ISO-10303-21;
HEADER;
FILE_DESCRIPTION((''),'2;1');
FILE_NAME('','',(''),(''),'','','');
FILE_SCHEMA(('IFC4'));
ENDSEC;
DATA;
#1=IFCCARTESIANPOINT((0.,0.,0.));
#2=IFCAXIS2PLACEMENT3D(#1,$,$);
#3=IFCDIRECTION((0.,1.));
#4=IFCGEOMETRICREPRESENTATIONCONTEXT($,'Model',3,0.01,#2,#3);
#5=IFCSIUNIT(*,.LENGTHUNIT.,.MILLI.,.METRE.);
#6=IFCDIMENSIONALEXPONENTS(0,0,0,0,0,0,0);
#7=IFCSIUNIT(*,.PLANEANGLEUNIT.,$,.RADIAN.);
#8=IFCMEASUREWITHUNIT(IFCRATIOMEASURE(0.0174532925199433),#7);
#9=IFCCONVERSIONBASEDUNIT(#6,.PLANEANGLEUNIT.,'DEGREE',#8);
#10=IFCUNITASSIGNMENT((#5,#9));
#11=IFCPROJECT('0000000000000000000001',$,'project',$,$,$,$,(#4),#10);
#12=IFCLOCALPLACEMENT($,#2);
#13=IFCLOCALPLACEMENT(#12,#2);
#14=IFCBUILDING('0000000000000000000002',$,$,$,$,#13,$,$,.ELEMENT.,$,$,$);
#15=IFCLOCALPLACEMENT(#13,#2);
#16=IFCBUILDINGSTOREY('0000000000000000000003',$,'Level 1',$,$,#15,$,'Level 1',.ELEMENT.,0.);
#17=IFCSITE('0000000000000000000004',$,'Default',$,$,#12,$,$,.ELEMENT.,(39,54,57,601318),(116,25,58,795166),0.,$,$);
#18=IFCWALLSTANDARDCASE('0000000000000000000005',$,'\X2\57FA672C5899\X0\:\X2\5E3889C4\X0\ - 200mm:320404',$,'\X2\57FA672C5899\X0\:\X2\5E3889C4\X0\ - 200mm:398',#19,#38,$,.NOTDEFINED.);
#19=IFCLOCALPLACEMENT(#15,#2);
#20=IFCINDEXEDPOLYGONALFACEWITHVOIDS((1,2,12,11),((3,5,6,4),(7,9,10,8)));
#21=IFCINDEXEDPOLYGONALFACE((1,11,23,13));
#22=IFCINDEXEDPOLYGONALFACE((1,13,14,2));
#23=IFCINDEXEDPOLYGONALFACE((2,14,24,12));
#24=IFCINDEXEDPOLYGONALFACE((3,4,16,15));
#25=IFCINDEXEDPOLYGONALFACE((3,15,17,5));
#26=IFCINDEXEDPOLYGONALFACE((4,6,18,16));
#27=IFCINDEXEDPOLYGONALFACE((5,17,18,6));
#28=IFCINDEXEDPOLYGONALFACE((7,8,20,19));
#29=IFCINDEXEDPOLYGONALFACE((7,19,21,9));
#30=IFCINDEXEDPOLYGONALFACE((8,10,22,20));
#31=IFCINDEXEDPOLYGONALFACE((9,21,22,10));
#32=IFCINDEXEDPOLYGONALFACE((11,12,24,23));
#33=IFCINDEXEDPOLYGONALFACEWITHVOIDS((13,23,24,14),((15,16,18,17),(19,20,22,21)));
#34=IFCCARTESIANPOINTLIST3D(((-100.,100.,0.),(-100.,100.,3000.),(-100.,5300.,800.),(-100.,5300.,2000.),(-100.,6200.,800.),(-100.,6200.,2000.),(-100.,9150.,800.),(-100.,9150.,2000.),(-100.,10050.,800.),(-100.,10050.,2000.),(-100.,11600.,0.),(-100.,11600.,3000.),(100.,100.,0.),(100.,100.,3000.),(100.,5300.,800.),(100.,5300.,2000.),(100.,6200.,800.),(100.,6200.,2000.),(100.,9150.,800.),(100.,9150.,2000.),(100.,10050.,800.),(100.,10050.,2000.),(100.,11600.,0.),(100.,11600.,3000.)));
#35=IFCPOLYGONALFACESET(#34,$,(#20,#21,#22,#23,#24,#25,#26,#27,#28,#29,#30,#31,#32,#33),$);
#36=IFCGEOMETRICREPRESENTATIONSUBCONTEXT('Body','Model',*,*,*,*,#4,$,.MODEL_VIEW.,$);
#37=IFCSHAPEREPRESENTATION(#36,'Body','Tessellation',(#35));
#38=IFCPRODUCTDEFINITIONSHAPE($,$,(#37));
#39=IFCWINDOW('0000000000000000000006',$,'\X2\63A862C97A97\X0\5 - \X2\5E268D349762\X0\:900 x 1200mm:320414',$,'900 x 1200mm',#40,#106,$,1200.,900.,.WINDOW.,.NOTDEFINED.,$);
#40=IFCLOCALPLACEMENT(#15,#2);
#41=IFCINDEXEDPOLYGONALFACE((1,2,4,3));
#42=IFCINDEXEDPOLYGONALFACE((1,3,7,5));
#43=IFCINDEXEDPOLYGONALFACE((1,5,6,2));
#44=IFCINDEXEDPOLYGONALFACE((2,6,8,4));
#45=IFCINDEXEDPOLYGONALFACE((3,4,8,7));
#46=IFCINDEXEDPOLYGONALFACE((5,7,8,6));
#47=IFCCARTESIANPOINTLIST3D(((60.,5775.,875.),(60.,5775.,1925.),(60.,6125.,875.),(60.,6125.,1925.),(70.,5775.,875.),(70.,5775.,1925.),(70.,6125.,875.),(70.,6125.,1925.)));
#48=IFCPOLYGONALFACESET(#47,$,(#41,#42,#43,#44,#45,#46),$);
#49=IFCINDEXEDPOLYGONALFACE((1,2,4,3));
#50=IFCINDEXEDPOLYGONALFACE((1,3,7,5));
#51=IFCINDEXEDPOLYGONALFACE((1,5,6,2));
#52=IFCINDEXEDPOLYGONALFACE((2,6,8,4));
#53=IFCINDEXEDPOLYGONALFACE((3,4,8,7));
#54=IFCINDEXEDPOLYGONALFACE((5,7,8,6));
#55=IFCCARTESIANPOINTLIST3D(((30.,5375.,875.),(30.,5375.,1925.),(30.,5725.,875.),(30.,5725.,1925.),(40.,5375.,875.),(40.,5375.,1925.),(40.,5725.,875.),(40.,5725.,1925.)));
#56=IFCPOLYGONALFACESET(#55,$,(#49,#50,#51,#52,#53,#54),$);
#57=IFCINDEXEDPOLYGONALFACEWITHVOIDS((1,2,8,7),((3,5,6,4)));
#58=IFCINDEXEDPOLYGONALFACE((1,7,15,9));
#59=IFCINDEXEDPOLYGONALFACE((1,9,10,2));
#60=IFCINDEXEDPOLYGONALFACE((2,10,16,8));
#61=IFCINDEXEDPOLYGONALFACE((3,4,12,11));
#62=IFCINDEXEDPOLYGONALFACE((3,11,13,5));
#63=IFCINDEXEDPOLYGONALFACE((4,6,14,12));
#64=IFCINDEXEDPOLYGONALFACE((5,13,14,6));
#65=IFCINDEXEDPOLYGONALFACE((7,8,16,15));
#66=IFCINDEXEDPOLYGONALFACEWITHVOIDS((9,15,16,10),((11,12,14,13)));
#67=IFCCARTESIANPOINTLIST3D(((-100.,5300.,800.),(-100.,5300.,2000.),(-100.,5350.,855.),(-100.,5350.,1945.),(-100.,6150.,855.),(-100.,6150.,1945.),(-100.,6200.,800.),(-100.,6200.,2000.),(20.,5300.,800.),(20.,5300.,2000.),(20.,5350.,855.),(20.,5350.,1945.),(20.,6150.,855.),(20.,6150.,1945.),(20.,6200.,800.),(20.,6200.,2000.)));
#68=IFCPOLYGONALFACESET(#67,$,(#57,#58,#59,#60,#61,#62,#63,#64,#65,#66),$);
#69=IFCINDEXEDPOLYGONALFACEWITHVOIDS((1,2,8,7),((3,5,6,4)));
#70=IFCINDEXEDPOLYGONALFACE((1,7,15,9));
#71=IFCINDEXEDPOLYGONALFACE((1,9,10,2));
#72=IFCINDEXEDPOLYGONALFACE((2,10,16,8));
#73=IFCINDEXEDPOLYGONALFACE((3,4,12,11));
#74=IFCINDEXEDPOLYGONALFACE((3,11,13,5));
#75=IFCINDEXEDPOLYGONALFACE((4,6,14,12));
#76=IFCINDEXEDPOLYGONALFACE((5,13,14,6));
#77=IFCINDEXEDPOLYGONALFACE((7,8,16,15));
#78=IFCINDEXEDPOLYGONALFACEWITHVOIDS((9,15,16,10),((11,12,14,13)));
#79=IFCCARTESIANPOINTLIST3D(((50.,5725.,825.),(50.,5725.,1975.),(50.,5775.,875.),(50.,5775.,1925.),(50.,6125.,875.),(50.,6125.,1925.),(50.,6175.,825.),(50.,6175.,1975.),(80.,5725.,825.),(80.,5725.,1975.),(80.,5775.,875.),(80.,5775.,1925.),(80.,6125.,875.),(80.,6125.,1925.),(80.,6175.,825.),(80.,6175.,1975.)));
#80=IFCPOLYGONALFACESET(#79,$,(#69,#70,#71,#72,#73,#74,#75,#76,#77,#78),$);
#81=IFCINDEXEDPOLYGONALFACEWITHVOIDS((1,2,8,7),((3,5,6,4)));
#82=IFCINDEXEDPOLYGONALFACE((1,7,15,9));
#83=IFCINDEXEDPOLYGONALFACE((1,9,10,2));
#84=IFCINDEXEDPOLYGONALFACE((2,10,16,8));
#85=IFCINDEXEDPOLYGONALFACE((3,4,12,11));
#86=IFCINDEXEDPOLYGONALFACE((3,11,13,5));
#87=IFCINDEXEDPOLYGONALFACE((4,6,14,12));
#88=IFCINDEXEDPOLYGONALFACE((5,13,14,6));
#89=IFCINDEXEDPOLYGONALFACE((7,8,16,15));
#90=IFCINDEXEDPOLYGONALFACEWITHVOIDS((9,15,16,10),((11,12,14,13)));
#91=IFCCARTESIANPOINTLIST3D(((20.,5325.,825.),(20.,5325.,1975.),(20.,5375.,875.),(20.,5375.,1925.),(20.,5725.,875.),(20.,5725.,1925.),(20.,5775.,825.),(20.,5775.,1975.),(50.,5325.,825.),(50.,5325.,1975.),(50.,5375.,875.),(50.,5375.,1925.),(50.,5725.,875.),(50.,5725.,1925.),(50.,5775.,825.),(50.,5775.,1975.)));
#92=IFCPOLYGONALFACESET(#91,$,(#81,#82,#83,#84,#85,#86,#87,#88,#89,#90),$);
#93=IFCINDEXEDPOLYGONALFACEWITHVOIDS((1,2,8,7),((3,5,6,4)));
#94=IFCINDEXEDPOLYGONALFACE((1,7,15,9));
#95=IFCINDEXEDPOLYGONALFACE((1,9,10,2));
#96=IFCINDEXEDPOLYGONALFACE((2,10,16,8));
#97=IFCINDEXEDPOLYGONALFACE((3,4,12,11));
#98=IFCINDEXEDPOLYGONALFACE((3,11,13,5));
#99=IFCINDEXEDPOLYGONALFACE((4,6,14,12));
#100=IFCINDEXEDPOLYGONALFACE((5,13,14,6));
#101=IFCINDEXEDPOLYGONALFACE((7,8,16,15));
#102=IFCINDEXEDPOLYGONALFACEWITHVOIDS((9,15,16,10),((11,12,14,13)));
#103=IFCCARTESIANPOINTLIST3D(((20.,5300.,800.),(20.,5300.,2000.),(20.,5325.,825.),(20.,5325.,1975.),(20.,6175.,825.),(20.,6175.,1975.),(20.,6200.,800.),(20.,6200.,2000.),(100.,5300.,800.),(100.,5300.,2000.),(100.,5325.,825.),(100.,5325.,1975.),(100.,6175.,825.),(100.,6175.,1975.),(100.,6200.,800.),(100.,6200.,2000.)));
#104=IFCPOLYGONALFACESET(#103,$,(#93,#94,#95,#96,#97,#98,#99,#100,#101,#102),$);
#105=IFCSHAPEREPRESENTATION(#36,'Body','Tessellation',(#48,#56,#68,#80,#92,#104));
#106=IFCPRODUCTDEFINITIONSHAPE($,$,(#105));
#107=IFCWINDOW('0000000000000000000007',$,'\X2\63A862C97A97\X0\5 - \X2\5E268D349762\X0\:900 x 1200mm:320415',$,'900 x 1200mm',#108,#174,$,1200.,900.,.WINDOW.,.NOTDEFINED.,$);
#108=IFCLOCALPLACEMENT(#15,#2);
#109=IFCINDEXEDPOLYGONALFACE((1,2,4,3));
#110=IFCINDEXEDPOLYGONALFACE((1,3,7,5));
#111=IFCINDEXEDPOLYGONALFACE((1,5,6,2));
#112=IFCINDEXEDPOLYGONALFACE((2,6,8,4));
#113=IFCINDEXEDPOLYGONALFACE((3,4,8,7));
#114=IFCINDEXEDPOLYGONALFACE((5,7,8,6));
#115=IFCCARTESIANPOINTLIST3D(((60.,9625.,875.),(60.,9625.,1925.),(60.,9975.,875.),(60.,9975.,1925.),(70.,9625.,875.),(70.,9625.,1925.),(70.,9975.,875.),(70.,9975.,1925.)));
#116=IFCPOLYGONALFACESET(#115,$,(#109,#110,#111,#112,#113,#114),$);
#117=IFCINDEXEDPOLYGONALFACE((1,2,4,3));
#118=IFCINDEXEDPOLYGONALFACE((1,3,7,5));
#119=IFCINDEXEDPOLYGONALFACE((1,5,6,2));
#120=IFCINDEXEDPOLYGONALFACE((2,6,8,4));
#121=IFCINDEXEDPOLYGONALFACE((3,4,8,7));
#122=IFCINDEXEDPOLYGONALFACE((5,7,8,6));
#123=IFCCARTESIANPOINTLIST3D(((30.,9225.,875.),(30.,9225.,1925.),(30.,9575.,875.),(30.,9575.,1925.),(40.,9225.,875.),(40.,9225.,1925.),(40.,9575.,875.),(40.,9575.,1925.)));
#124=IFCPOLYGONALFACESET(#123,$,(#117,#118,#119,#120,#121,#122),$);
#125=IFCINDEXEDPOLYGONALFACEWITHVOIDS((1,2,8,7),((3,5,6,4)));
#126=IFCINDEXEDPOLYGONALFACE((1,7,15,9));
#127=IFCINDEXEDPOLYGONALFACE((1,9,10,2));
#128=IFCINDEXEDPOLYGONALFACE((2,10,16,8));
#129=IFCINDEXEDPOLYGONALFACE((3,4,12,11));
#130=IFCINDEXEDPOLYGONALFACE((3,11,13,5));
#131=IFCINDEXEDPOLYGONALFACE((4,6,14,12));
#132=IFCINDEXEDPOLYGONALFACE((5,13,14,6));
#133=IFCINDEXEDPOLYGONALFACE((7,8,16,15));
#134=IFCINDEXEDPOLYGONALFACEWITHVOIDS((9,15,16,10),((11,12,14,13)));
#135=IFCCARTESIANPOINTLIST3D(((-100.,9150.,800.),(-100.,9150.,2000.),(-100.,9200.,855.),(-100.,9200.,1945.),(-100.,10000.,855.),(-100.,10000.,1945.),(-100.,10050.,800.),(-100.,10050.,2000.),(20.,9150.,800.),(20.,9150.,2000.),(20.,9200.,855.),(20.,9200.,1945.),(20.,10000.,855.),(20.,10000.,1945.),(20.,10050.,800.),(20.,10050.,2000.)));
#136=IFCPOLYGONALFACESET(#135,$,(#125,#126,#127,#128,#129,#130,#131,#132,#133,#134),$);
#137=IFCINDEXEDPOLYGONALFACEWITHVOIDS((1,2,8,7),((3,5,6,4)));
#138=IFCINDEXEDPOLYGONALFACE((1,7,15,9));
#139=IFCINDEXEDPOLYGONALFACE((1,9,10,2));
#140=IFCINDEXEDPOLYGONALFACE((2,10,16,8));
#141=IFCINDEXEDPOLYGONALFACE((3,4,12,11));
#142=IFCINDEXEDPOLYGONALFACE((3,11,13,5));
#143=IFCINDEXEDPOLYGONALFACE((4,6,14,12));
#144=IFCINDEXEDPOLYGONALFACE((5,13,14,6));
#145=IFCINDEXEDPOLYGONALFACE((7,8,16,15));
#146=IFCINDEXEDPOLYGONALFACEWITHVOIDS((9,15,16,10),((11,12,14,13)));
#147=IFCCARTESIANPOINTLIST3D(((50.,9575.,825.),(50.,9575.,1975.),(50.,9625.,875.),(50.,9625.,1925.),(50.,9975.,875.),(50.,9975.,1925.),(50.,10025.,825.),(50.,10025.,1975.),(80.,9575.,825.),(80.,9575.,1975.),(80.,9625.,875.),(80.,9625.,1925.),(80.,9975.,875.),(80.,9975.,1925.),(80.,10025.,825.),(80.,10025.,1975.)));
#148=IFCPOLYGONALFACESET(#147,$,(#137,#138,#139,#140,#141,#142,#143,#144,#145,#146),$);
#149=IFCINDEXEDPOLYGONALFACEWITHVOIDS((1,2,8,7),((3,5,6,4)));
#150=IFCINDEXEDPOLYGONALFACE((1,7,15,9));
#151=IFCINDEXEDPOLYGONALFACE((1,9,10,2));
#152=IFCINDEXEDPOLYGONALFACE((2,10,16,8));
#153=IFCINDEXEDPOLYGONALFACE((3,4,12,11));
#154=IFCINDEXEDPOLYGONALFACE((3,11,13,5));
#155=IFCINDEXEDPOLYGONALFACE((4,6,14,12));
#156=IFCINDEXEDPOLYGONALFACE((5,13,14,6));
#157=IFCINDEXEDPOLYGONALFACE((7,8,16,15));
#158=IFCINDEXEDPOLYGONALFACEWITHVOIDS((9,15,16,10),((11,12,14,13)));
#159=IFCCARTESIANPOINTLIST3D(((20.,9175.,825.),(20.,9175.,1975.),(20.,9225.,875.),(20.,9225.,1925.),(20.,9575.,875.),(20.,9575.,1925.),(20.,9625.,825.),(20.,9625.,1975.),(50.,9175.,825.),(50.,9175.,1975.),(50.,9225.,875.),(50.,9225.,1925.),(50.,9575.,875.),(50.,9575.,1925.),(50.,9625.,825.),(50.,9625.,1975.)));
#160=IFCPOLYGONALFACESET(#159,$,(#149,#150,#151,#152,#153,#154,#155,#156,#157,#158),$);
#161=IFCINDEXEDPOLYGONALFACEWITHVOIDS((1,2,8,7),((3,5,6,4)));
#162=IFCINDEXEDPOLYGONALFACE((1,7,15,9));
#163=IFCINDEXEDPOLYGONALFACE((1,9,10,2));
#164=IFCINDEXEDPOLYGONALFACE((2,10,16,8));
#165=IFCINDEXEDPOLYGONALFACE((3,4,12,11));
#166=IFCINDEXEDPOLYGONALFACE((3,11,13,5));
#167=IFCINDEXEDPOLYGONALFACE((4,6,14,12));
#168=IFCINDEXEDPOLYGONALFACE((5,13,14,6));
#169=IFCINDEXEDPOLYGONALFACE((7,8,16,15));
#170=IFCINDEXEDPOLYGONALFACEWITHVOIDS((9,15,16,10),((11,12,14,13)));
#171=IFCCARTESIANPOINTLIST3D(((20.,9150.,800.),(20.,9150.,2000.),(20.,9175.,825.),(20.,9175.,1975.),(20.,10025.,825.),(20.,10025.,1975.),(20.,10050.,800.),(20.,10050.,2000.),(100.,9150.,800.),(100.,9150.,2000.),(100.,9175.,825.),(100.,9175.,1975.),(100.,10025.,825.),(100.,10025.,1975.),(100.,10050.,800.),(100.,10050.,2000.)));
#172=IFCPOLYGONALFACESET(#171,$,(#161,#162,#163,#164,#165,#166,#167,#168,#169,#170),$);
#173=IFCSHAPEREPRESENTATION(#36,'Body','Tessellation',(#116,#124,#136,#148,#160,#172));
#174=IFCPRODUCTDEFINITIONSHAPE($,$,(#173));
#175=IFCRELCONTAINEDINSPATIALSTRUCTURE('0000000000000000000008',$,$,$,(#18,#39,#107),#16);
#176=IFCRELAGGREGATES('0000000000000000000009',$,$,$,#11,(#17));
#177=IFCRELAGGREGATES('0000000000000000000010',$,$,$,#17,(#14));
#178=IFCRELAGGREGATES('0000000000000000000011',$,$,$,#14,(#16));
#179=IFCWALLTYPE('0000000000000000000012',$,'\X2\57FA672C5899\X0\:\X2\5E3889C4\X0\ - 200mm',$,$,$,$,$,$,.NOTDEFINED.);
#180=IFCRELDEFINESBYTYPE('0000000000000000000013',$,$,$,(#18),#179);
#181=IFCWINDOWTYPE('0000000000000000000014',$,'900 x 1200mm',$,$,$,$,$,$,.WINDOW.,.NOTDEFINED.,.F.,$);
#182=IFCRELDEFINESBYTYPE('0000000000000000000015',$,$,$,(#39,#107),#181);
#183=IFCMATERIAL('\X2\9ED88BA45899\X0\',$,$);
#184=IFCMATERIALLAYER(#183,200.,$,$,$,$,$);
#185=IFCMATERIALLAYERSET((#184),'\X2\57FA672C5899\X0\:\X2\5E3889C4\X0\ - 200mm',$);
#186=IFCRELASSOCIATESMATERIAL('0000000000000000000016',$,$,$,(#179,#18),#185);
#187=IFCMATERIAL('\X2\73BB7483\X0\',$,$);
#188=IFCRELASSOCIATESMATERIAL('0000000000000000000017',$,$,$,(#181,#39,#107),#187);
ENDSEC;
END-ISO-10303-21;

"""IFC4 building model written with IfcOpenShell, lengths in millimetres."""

from ifc_helpers import new_model, entity, si_unit, converted_unit, direction, frame, frame_2d, origin, origin_2d_with_axis, place, context, subcontext, project, spatial, polyline, rectangle, outline, extrude, source, transform, mapped, material, layer, layer_set, layer_usage, type_object, type_shapes, element, fill, save


model = new_model("IFC4")

# Units and contexts
model_context = context("Model", 3, precision=0.01, world=origin(), true_north=direction((0.0, 1.0)))
body_context = subcontext(model_context, "Body", "Model", "MODEL_VIEW")
ifc_project = project(units=[si_unit("LENGTHUNIT", "METRE", prefix="MILLI"), converted_unit("PLANEANGLEUNIT", "DEGREE", entity("IfcRatioMeasure", 0.0174532925199433), si_unit("PLANEANGLEUNIT", "RADIAN"), dimensions=[0, 0, 0, 0, 0, 0, 0])], contexts=[model_context])

# Site, building, storey
site_placement = place(None, origin())
site = spatial("IfcSite", under=ifc_project, at=site_placement, Name="Default", CompositionType="ELEMENT", RefLatitude=(39, 54, 57, 601318), RefLongitude=(116, 25, 58, 795166), RefElevation=0.0)
building_placement = place(site_placement, origin())
building = spatial("IfcBuilding", under=site, at=building_placement, CompositionType="ELEMENT")
storey_placement = place(building_placement, origin())
storey = spatial("IfcBuildingStorey", under=building, at=storey_placement, Name="Level 1", LongName="Level 1", CompositionType="ELEMENT", Elevation=0.0)

# Wall, openings, windows
ifc_material_1 = material(Name="默认墙")
ifc_layer_1 = layer(ifc_material_1, 200.0)
ifc_layer_set_1 = layer_set([ifc_layer_1], Name="基本墙:常规 - 200mm")
ifc_layer_usage_1 = layer_usage(ifc_layer_set_1, "AXIS2", "NEGATIVE", 100.0)
wall_type = type_object("IfcWallType", Name="基本墙:常规 - 200mm", PredefinedType="NOTDEFINED", material=ifc_layer_set_1)
wall_1_placement = place(storey_placement, frame((0.0, 100.0, 0.0), z_axis=(0.0, 0.0, 1.0), x_axis=(0.0, 1.0, 0.0)))
wall_1 = element("IfcWallStandardCase", 1, at=wall_1_placement, inside=storey, type_object=wall_type, material=ifc_layer_usage_1, Name="基本墙:常规 - 200mm:320404", ObjectType="基本墙:常规 - 200mm:398", PredefinedType="NOTDEFINED", context=body_context, shape_type="SweptSolid", body=[
    extrude(rectangle(XDim=11500.0, YDim=200.0, at=frame_2d((5750.0, 0.0), x_axis=(-1.0, 0.0))), origin(), (0.0, 0.0, 1.0), 3000.0),
])
opening_1_placement = place(wall_1_placement, frame((6100.0, 100.0, 800.0)))
opening_1 = element("IfcOpeningElement", 2, at=opening_1_placement, cuts=wall_1, ObjectType="Opening", PredefinedType="OPENING", context=body_context, shape_type="SweptSolid", body=[
    extrude(rectangle(XDim=1200.0, YDim=900.0, at=frame_2d((600.0, 450.0), x_axis=(-1.0, 0.0))), frame((0.0, 0.0, 0.0), z_axis=(0.0, -1.0, 0.0), x_axis=(0.0, 0.0, 1.0)), (0.0, 0.0, 1.0), 200.0),
])
opening_2_placement = place(wall_1_placement, frame((9950.0, 100.0, 800.0)))
opening_2 = element("IfcOpeningElement", 3, at=opening_2_placement, cuts=wall_1, ObjectType="Opening", PredefinedType="OPENING", context=body_context, shape_type="SweptSolid", body=[
    extrude(rectangle(XDim=1200.0, YDim=900.0, at=frame_2d((600.0, 450.0), x_axis=(-1.0, 0.0))), frame((0.0, 0.0, 0.0), z_axis=(0.0, -1.0, 0.0), x_axis=(0.0, 0.0, 1.0)), (0.0, 0.0, 1.0), 200.0),
])
ifc_material_2 = material(Name="玻璃")
window_type_1 = type_object("IfcWindowType", Name="900 x 1200mm", ParameterTakesPrecedence=False, PartitioningType="NOTDEFINED", PredefinedType="WINDOW", material=ifc_material_2)
shared_shape_1 = source(origin(), body_context, "Body", "SweptSolid", [
    extrude(rectangle(XDim=10.0, YDim=350.0, at=origin_2d_with_axis()), frame((250.0, 165.0, 75.0), z_axis=(0.0, 0.0, 1.0), x_axis=(0.0, -1.0, 0.0)), (0.0, 0.0, 1.0), 1050.0),
    extrude(rectangle(XDim=10.0, YDim=350.0, at=frame_2d((0.0, 0.0), x_axis=(1.0, 0.0))), frame((650.0, 135.0, 75.0), z_axis=(0.0, 0.0, 1.0), x_axis=(0.0, -1.0, 0.0)), (0.0, 0.0, 1.0), 1050.0),
    extrude(outline(polyline([(-450.0, -600.0), (450.0, -600.0), (450.0, 600.0), (-450.0, 600.0), (-450.0, -600.0)]), holes=[polyline([(400.0, -545.0), (-400.0, -545.0), (-400.0, 545.0), (400.0, 545.0), (400.0, -545.0)])]), frame((450.0, 0.0, 600.0), z_axis=(0.0, 1.0, 0.0), x_axis=(1.0, 0.0, 0.0)), (0.0, 0.0, 1.0), 120.0),
    extrude(outline(polyline([(-225.0, -575.0), (225.0, -575.0), (225.0, 575.0), (-225.0, 575.0), (-225.0, -575.0)]), holes=[polyline([(-175.0, -525.0), (-175.0, 525.0), (175.0, 525.0), (175.0, -525.0), (-175.0, -525.0)])]), frame((250.0, 150.0, 600.0), z_axis=(0.0, 1.0, 0.0), x_axis=(-1.0, 0.0, 0.0)), (0.0, 0.0, 1.0), 30.0),
    extrude(outline(polyline([(-225.0, -575.0), (225.0, -575.0), (225.0, 575.0), (-225.0, 575.0), (-225.0, -575.0)]), holes=[polyline([(-175.0, -525.0), (-175.0, 525.0), (175.0, 525.0), (175.0, -525.0), (-175.0, -525.0)])]), frame((650.0, 120.0, 600.0), z_axis=(0.0, 1.0, 0.0), x_axis=(1.0, 0.0, 0.0)), (0.0, 0.0, 1.0), 30.0),
    extrude(outline(polyline([(-450.0, -600.0), (450.0, -600.0), (450.0, 600.0), (-450.0, 600.0), (-450.0, -600.0)]), holes=[polyline([(-425.0, 575.0), (425.0, 575.0), (425.0, -575.0), (-425.0, -575.0), (-425.0, 575.0)])]), frame((450.0, 120.0, 600.0), z_axis=(0.0, 1.0, 0.0), x_axis=(1.0, 0.0, 0.0)), (0.0, 0.0, 1.0), 80.0),
])
type_shapes(window_type_1, [shared_shape_1])
window_1_placement = place(opening_1_placement, frame((0.0, 0.0, 0.0), z_axis=(0.0, 0.0, 1.0), x_axis=(-1.0, 0.0, 0.0)))
window_1 = element("IfcWindow", 4, at=window_1_placement, inside=storey, type_object=window_type_1, material=ifc_material_2, Name="推拉窗5 - 带贴面:900 x 1200mm:320414", ObjectType="900 x 1200mm", OverallHeight=1200.0, OverallWidth=900.0, PartitioningType="NOTDEFINED", PredefinedType="WINDOW", context=body_context, shape_type="MappedRepresentation", body=[
    mapped(shared_shape_1, transform((0.0, 0.0, 0.0), scale=1.0)),
])
fill(opening_1, window_1)
window_2_placement = place(opening_2_placement, frame((0.0, 0.0, 0.0), z_axis=(0.0, 0.0, 1.0), x_axis=(-1.0, 0.0, 0.0)))
window_2 = element("IfcWindow", 5, at=window_2_placement, inside=storey, type_object=window_type_1, material=ifc_material_2, Name="推拉窗5 - 带贴面:900 x 1200mm:320415", ObjectType="900 x 1200mm", OverallHeight=1200.0, OverallWidth=900.0, PartitioningType="NOTDEFINED", PredefinedType="WINDOW", context=body_context, shape_type="MappedRepresentation", body=[
    mapped(shared_shape_1, transform((0.0, 0.0, 0.0), scale=1.0)),
])
fill(opening_2, window_2)

save(model, "model.ifc")
